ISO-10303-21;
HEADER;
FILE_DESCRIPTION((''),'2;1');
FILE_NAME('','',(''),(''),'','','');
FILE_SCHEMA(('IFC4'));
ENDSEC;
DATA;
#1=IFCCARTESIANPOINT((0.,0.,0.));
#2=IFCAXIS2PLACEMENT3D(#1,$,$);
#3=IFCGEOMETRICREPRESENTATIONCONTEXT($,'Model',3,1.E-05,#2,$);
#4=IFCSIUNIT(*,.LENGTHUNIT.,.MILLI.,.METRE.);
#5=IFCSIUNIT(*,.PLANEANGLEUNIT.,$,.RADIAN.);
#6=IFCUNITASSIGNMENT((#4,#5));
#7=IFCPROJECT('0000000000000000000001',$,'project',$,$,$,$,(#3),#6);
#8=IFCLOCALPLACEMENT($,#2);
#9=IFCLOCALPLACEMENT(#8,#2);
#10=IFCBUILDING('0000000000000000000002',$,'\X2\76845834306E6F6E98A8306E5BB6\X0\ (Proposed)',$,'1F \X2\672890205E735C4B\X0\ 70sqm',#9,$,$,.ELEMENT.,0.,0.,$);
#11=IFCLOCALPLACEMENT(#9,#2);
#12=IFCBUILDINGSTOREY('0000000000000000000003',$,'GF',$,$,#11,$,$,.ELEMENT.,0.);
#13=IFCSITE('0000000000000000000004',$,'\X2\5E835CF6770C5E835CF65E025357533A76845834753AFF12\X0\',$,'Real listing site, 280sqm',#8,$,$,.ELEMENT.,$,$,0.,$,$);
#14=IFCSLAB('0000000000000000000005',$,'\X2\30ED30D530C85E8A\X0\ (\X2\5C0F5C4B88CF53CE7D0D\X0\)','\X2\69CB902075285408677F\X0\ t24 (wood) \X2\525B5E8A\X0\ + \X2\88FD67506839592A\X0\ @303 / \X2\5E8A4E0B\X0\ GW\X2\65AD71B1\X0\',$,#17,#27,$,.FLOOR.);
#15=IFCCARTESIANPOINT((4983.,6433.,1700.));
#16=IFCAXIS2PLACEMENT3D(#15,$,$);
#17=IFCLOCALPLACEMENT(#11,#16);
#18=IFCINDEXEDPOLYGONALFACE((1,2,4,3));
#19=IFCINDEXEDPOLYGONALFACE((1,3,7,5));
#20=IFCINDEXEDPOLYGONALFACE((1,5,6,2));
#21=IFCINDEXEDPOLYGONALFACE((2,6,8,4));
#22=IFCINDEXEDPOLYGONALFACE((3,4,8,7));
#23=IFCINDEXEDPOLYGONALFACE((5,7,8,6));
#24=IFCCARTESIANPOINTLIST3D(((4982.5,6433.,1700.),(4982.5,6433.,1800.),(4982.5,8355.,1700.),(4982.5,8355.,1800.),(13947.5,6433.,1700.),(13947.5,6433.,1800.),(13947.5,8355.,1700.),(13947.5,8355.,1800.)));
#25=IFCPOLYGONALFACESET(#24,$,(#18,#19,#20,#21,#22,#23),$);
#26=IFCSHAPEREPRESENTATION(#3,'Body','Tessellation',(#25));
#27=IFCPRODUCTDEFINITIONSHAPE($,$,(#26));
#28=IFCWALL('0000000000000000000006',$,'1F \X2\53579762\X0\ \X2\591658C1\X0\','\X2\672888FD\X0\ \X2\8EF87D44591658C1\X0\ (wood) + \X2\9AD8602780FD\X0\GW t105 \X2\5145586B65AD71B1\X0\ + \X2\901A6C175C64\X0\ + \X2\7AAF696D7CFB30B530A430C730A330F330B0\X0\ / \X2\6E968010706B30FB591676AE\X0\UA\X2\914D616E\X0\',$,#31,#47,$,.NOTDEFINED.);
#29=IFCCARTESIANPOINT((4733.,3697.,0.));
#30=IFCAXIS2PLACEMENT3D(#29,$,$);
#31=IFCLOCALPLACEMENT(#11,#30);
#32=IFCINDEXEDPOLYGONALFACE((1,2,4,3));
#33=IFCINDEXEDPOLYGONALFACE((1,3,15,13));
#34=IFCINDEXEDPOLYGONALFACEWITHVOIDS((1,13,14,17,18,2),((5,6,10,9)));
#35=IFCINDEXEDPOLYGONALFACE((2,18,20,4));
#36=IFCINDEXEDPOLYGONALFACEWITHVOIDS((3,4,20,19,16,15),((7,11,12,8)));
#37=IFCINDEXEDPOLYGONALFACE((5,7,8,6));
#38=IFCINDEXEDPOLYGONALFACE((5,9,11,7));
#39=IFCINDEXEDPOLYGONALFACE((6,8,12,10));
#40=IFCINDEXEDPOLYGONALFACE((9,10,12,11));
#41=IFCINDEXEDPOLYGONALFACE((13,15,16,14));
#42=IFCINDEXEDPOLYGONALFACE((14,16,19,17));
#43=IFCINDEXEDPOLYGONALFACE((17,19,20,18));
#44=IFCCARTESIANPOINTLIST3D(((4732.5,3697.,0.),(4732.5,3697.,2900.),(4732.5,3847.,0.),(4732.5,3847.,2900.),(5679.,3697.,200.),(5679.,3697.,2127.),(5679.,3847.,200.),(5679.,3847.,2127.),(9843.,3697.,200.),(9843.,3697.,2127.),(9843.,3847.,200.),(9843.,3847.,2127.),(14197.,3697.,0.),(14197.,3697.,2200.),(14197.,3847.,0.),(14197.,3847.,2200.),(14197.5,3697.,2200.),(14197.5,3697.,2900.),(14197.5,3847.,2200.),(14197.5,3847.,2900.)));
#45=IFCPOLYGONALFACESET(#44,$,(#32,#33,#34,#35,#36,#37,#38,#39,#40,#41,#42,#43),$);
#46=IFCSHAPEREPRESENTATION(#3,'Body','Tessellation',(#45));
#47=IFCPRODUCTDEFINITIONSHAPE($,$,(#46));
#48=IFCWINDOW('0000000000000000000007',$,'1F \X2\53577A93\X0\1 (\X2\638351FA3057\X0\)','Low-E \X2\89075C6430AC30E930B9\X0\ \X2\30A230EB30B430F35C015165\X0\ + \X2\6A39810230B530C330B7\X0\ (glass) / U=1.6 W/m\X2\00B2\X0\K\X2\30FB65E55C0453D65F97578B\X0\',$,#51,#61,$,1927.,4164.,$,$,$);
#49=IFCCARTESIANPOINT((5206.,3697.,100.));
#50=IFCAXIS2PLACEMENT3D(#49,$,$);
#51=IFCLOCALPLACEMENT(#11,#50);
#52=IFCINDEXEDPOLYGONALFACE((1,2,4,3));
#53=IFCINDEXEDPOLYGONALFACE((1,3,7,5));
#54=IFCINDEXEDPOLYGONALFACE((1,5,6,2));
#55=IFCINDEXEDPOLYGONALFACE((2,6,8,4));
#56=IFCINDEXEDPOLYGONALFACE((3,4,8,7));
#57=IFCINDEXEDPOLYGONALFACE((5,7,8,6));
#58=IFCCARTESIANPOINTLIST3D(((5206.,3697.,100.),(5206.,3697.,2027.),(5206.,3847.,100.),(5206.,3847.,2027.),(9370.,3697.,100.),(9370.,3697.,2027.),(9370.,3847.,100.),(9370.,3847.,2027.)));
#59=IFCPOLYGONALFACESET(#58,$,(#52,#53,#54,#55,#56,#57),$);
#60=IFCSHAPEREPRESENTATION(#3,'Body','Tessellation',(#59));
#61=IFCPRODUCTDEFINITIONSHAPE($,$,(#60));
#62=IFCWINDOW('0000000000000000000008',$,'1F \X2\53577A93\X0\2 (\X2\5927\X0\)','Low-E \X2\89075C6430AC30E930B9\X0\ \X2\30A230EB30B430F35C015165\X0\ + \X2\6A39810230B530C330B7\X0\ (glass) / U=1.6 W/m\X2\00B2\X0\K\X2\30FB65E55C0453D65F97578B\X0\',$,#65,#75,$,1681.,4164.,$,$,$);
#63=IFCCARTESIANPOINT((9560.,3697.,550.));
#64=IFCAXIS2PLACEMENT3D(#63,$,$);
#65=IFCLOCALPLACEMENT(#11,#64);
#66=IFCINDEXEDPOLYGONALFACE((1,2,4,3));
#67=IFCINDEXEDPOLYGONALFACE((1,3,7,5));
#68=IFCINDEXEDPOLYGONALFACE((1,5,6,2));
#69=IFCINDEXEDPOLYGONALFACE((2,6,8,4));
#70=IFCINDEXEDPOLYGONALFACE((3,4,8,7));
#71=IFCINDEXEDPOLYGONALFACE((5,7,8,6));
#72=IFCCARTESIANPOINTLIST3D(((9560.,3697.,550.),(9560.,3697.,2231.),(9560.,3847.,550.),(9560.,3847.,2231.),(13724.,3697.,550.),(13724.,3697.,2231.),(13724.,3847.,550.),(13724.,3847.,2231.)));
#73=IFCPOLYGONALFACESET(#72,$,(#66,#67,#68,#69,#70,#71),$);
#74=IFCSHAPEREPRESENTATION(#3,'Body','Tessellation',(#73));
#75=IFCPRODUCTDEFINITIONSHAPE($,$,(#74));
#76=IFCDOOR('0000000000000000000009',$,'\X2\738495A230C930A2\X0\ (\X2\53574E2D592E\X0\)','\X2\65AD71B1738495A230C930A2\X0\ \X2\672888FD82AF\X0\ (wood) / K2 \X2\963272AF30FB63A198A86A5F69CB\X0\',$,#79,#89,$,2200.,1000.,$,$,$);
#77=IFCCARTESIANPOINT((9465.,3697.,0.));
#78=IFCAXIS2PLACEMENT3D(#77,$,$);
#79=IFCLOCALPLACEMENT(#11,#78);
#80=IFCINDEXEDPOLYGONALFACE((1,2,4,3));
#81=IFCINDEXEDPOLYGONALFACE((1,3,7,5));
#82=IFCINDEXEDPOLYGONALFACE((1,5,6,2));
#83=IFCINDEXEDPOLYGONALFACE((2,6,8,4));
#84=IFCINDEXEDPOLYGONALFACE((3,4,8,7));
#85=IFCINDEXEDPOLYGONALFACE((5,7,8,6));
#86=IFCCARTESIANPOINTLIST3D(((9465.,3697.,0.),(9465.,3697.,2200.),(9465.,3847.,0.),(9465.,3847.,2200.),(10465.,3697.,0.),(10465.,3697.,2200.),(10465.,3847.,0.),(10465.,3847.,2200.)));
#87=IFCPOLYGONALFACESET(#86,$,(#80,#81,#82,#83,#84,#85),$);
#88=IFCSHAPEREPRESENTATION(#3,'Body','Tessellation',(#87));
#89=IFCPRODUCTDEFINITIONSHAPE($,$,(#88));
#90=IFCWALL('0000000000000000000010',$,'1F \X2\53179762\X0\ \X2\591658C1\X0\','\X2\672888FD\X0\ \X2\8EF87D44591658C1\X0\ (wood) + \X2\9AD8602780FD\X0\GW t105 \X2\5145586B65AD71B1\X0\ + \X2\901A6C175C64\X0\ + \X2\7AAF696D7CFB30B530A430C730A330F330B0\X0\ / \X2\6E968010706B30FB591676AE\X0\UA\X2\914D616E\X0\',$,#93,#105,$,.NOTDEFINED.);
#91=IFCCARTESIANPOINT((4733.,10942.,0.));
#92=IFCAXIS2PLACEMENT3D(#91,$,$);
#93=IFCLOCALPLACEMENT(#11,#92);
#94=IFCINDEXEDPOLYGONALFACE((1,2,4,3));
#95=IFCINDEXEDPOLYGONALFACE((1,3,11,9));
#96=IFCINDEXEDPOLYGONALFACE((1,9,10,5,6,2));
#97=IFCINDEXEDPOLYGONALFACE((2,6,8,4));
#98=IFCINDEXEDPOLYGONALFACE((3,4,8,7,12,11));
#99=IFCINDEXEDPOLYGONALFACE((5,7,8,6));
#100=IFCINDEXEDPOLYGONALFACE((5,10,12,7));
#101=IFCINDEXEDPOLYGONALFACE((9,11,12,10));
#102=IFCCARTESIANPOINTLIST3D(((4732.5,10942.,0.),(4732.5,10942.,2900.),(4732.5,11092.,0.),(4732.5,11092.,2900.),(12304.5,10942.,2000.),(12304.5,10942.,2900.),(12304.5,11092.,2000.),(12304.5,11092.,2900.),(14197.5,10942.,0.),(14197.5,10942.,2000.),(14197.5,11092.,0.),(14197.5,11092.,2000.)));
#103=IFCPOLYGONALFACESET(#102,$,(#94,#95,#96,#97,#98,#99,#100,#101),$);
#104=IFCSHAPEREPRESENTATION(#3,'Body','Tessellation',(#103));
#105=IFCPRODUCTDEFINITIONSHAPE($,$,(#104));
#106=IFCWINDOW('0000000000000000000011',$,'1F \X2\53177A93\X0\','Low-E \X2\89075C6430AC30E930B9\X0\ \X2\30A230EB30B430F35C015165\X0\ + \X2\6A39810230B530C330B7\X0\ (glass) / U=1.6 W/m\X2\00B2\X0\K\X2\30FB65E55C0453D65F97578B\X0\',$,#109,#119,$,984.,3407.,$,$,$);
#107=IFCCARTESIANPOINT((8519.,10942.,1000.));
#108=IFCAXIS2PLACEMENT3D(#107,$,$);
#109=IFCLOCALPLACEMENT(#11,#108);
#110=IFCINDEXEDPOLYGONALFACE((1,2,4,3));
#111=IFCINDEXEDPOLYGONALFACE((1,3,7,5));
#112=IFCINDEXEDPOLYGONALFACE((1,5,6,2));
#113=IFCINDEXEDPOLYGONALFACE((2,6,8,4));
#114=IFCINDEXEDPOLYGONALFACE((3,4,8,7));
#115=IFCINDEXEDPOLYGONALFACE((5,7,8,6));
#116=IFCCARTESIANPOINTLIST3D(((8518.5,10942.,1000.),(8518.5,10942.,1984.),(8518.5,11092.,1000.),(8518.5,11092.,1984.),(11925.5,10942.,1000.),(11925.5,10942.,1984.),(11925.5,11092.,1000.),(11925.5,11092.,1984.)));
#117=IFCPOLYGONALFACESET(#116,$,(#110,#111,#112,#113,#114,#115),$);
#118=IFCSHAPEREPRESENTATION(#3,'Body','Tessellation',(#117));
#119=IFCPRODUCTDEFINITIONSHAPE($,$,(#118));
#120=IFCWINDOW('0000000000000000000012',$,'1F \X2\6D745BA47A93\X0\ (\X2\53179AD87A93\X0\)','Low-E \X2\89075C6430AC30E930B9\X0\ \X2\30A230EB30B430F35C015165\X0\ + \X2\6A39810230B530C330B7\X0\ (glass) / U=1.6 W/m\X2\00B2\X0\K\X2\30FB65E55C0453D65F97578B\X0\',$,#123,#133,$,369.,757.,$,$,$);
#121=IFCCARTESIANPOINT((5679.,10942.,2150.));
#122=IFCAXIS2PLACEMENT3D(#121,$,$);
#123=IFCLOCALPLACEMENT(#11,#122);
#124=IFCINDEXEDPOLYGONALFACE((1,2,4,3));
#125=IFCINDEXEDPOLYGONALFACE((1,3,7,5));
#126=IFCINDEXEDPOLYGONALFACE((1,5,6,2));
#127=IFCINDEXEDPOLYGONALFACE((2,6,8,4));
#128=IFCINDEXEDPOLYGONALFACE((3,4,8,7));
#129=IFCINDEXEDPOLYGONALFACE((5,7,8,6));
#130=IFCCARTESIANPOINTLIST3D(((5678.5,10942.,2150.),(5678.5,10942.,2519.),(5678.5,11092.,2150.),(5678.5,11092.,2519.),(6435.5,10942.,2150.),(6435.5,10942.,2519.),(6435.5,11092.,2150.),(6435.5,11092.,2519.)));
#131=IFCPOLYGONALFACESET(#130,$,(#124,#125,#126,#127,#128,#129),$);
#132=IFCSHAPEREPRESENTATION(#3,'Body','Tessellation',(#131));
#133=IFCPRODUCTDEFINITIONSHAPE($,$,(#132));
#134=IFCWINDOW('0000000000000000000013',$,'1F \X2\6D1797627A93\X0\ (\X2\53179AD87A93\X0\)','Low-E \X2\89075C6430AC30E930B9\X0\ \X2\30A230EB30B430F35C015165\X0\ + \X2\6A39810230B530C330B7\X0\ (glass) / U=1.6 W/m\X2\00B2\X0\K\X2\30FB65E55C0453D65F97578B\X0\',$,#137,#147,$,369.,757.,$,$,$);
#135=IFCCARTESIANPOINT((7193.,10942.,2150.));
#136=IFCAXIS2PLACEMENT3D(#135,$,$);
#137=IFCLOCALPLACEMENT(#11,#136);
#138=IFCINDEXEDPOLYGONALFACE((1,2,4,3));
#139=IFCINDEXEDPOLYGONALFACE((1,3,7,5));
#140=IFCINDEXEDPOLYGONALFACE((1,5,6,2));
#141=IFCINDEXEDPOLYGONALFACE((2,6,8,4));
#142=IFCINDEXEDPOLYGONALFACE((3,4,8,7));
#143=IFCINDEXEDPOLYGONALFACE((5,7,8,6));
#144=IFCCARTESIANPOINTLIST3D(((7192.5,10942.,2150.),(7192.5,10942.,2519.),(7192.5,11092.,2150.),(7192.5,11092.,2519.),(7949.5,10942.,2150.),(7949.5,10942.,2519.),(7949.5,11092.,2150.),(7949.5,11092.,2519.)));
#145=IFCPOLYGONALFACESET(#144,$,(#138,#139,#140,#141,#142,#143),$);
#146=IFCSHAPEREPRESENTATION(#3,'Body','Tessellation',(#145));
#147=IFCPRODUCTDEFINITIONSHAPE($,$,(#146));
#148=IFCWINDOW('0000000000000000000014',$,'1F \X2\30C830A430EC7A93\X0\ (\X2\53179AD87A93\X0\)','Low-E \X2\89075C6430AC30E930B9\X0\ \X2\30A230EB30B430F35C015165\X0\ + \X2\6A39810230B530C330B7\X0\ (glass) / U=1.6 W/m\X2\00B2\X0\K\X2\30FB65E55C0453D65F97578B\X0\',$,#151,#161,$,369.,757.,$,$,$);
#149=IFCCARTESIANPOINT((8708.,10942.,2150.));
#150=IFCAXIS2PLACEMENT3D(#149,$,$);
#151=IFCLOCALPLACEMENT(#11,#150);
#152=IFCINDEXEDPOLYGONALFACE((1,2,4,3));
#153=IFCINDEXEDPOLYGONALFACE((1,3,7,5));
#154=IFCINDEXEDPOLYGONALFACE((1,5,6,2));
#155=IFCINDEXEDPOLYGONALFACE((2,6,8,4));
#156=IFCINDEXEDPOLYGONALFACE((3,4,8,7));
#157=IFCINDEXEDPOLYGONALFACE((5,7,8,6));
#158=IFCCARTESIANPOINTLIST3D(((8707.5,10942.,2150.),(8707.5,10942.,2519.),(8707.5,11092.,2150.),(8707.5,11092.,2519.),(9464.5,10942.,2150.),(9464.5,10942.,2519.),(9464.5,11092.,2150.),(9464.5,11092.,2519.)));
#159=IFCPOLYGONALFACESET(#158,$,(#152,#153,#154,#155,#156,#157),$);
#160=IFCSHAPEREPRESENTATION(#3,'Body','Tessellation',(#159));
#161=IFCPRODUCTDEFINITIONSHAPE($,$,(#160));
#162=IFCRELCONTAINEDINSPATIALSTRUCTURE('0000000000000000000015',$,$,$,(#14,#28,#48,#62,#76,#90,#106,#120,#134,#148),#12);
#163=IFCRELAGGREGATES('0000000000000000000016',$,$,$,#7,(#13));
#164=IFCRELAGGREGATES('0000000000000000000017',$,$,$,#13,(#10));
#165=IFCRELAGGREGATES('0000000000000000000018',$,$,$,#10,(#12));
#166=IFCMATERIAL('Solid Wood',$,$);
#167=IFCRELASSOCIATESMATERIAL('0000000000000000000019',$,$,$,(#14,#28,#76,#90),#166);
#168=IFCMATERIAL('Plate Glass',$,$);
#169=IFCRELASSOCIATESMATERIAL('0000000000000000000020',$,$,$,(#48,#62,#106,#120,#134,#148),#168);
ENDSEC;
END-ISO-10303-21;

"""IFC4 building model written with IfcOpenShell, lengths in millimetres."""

from ifc_helpers import new_model, si_unit, frame, frame_2d, origin, place, context, project, spatial, rectangle, extrude, material, element, fill, save


model = new_model("IFC4")

# Units and contexts
model_context = context("Model", 3, precision=1e-05, world=origin())
ifc_project = project(units=[si_unit("LENGTHUNIT", "METRE", prefix="MILLI"), si_unit("PLANEANGLEUNIT", "RADIAN")], contexts=[model_context])

# Site, building, storey
site_placement = place(None, origin())
site = spatial("IfcSite", under=ifc_project, at=site_placement, Name="広島県広島市南区的場町２", ObjectType="Real listing site, 280sqm", CompositionType="ELEMENT", RefElevation=0.0)
building_placement = place(site_placement, origin())
building = spatial("IfcBuilding", under=site, at=building_placement, Name="的場の潮風の家 (Proposed)", ObjectType="1F 木造平屋 70sqm", CompositionType="ELEMENT", ElevationOfRefHeight=0.0, ElevationOfTerrain=0.0)
storey_placement = place(building_placement, origin())
storey = spatial("IfcBuildingStorey", under=building, at=storey_placement, Name="GF", CompositionType="ELEMENT", Elevation=0.0)

# Slab
ifc_material_1 = material(Name="Solid Wood")
slab_1_placement = place(storey_placement, frame((4983.0, 6433.0, 1700.0)))
element("IfcSlab", 1, at=slab_1_placement, inside=storey, material=ifc_material_1, Name="ロフト床 (小屋裏収納)", Description="構造用合板 t24 (wood) 剛床 + 製材根太 @303 / 床下 GW断熱", PredefinedType="FLOOR", context=model_context, shape_type="SweptSolid", body=[
    extrude(rectangle(XDim=8965.0, YDim=1922.0, at=frame_2d((4482.0, 961.0))), frame((4983.0, 6433.0, 1700.0)), (0.0, 0.0, 1.0), 100.0),
])

# Wall, openings, windows, door
wall_1_placement = place(storey_placement, frame((4733.0, 3697.0, 0.0)))
wall_1 = element("IfcWall", 2, at=wall_1_placement, inside=storey, material=ifc_material_1, Name="1F 南面 外壁", Description="木製 軸組外壁 (wood) + 高性能GW t105 充填断熱 + 通気層 + 窯業系サイディング / 準耐火・外皮UA配慮", PredefinedType="NOTDEFINED", context=model_context, shape_type="SweptSolid", body=[
    extrude(rectangle(XDim=9465.0, YDim=150.0, at=frame_2d((4732.0, 75.0))), frame((4733.0, 3697.0, 0.0)), (0.0, 0.0, 1.0), 2900.0),
])
opening_1_placement = place(storey_placement, frame((5206.0, 3697.0, 100.0)))
opening_1 = element("IfcOpeningElement", 3, at=opening_1_placement, cuts=wall_1, PredefinedType="NOTDEFINED", context=model_context, shape_type="SweptSolid", body=[
    extrude(rectangle(XDim=4164.0, YDim=150.0, at=frame_2d((2082.0, 75.0))), frame((5206.0, 3697.0, 100.0)), (0.0, 0.0, 1.0), 1927.0),
])
opening_2_placement = place(storey_placement, frame((9560.0, 3697.0, 550.0)))
opening_2 = element("IfcOpeningElement", 4, at=opening_2_placement, cuts=wall_1, PredefinedType="NOTDEFINED", context=model_context, shape_type="SweptSolid", body=[
    extrude(rectangle(XDim=4164.0, YDim=150.0, at=frame_2d((2082.0, 75.0))), frame((9560.0, 3697.0, 550.0)), (0.0, 0.0, 1.0), 1681.0),
])
opening_3_placement = place(storey_placement, frame((9465.0, 3697.0, 0.0)))
opening_3 = element("IfcOpeningElement", 5, at=opening_3_placement, cuts=wall_1, PredefinedType="NOTDEFINED", context=model_context, shape_type="SweptSolid", body=[
    extrude(rectangle(XDim=1000.0, YDim=150.0, at=frame_2d((500.0, 75.0))), frame((9465.0, 3697.0, 0.0)), (0.0, 0.0, 1.0), 2200.0),
])
ifc_material_2 = material(Name="Plate Glass")
window_1_placement = place(storey_placement, frame((5206.0, 3697.0, 100.0)))
window_1 = element("IfcWindow", 6, at=window_1_placement, inside=storey, material=ifc_material_2, Name="1F 南窓1 (掃出し)", Description="Low-E 複層ガラス アルゴン封入 + 樹脂サッシ (glass) / U=1.6 W/m²K・日射取得型", OverallHeight=1927.0, OverallWidth=4164.0, context=model_context, shape_type="SweptSolid", body=[
    extrude(rectangle(XDim=4164.0, YDim=150.0, at=frame_2d((2082.0, 75.0))), frame((5206.0, 3697.0, 100.0)), (0.0, 0.0, 1.0), 1927.0),
])
fill(opening_1, window_1)
window_2_placement = place(storey_placement, frame((9560.0, 3697.0, 550.0)))
window_2 = element("IfcWindow", 7, at=window_2_placement, inside=storey, material=ifc_material_2, Name="1F 南窓2 (大)", Description="Low-E 複層ガラス アルゴン封入 + 樹脂サッシ (glass) / U=1.6 W/m²K・日射取得型", OverallHeight=1681.0, OverallWidth=4164.0, context=model_context, shape_type="SweptSolid", body=[
    extrude(rectangle(XDim=4164.0, YDim=150.0, at=frame_2d((2082.0, 75.0))), frame((9560.0, 3697.0, 550.0)), (0.0, 0.0, 1.0), 1681.0),
])
fill(opening_2, window_2)
door_1_placement = place(storey_placement, frame((9465.0, 3697.0, 0.0)))
door_1 = element("IfcDoor", 8, at=door_1_placement, inside=storey, material=ifc_material_1, Name="玄関ドア (南中央)", Description="断熱玄関ドア 木製芯 (wood) / K2 防犯・採風機構", OverallHeight=2200.0, OverallWidth=1000.0, context=model_context, shape_type="SweptSolid", body=[
    extrude(rectangle(XDim=1000.0, YDim=150.0, at=frame_2d((500.0, 75.0))), frame((9465.0, 3697.0, 0.0)), (0.0, 0.0, 1.0), 2200.0),
])
fill(opening_3, door_1)

# Wall, openings, windows
wall_2_placement = place(storey_placement, frame((4733.0, 10942.0, 0.0)))
wall_2 = element("IfcWall", 9, at=wall_2_placement, inside=storey, material=ifc_material_1, Name="1F 北面 外壁", Description="木製 軸組外壁 (wood) + 高性能GW t105 充填断熱 + 通気層 + 窯業系サイディング / 準耐火・外皮UA配慮", PredefinedType="NOTDEFINED", context=model_context, shape_type="SweptSolid", body=[
    extrude(rectangle(XDim=9465.0, YDim=150.0, at=frame_2d((4732.0, 75.0))), frame((4733.0, 10942.0, 0.0)), (0.0, 0.0, 1.0), 2900.0),
])
opening_4_placement = place(storey_placement, frame((8519.0, 10942.0, 1000.0)))
opening_4 = element("IfcOpeningElement", 10, at=opening_4_placement, cuts=wall_2, PredefinedType="NOTDEFINED", context=model_context, shape_type="SweptSolid", body=[
    extrude(rectangle(XDim=3407.0, YDim=150.0, at=frame_2d((1703.0, 75.0))), frame((8519.0, 10942.0, 1000.0)), (0.0, 0.0, 1.0), 984.0),
])
opening_5_placement = place(storey_placement, frame((5679.0, 10942.0, 2150.0)))
opening_5 = element("IfcOpeningElement", 11, at=opening_5_placement, cuts=wall_2, PredefinedType="NOTDEFINED", context=model_context, shape_type="SweptSolid", body=[
    extrude(rectangle(XDim=757.0, YDim=150.0, at=frame_2d((378.0, 75.0))), frame((5679.0, 10942.0, 2150.0)), (0.0, 0.0, 1.0), 369.0),
])
opening_6_placement = place(storey_placement, frame((7193.0, 10942.0, 2150.0)))
opening_6 = element("IfcOpeningElement", 12, at=opening_6_placement, cuts=wall_2, PredefinedType="NOTDEFINED", context=model_context, shape_type="SweptSolid", body=[
    extrude(rectangle(XDim=757.0, YDim=150.0, at=frame_2d((378.0, 75.0))), frame((7193.0, 10942.0, 2150.0)), (0.0, 0.0, 1.0), 369.0),
])
opening_7_placement = place(storey_placement, frame((8708.0, 10942.0, 2150.0)))
opening_7 = element("IfcOpeningElement", 13, at=opening_7_placement, cuts=wall_2, PredefinedType="NOTDEFINED", context=model_context, shape_type="SweptSolid", body=[
    extrude(rectangle(XDim=757.0, YDim=150.0, at=frame_2d((378.0, 75.0))), frame((8708.0, 10942.0, 2150.0)), (0.0, 0.0, 1.0), 369.0),
])
window_3_placement = place(storey_placement, frame((8519.0, 10942.0, 1000.0)))
window_3 = element("IfcWindow", 14, at=window_3_placement, inside=storey, material=ifc_material_2, Name="1F 北窓", Description="Low-E 複層ガラス アルゴン封入 + 樹脂サッシ (glass) / U=1.6 W/m²K・日射取得型", OverallHeight=984.0, OverallWidth=3407.0, context=model_context, shape_type="SweptSolid", body=[
    extrude(rectangle(XDim=3407.0, YDim=150.0, at=frame_2d((1703.0, 75.0))), frame((8519.0, 10942.0, 1000.0)), (0.0, 0.0, 1.0), 984.0),
])
fill(opening_4, window_3)
window_4_placement = place(storey_placement, frame((5679.0, 10942.0, 2150.0)))
window_4 = element("IfcWindow", 15, at=window_4_placement, inside=storey, material=ifc_material_2, Name="1F 浴室窓 (北高窓)", Description="Low-E 複層ガラス アルゴン封入 + 樹脂サッシ (glass) / U=1.6 W/m²K・日射取得型", OverallHeight=369.0, OverallWidth=757.0, context=model_context, shape_type="SweptSolid", body=[
    extrude(rectangle(XDim=757.0, YDim=150.0, at=frame_2d((378.0, 75.0))), frame((5679.0, 10942.0, 2150.0)), (0.0, 0.0, 1.0), 369.0),
])
fill(opening_5, window_4)
window_5_placement = place(storey_placement, frame((7193.0, 10942.0, 2150.0)))
window_5 = element("IfcWindow", 16, at=window_5_placement, inside=storey, material=ifc_material_2, Name="1F 洗面窓 (北高窓)", Description="Low-E 複層ガラス アルゴン封入 + 樹脂サッシ (glass) / U=1.6 W/m²K・日射取得型", OverallHeight=369.0, OverallWidth=757.0, context=model_context, shape_type="SweptSolid", body=[
    extrude(rectangle(XDim=757.0, YDim=150.0, at=frame_2d((378.0, 75.0))), frame((7193.0, 10942.0, 2150.0)), (0.0, 0.0, 1.0), 369.0),
])
fill(opening_6, window_5)
window_6_placement = place(storey_placement, frame((8708.0, 10942.0, 2150.0)))
window_6 = element("IfcWindow", 17, at=window_6_placement, inside=storey, material=ifc_material_2, Name="1F トイレ窓 (北高窓)", Description="Low-E 複層ガラス アルゴン封入 + 樹脂サッシ (glass) / U=1.6 W/m²K・日射取得型", OverallHeight=369.0, OverallWidth=757.0, context=model_context, shape_type="SweptSolid", body=[
    extrude(rectangle(XDim=757.0, YDim=150.0, at=frame_2d((378.0, 75.0))), frame((8708.0, 10942.0, 2150.0)), (0.0, 0.0, 1.0), 369.0),
])
fill(opening_7, window_6)

save(model, "model.ifc")
